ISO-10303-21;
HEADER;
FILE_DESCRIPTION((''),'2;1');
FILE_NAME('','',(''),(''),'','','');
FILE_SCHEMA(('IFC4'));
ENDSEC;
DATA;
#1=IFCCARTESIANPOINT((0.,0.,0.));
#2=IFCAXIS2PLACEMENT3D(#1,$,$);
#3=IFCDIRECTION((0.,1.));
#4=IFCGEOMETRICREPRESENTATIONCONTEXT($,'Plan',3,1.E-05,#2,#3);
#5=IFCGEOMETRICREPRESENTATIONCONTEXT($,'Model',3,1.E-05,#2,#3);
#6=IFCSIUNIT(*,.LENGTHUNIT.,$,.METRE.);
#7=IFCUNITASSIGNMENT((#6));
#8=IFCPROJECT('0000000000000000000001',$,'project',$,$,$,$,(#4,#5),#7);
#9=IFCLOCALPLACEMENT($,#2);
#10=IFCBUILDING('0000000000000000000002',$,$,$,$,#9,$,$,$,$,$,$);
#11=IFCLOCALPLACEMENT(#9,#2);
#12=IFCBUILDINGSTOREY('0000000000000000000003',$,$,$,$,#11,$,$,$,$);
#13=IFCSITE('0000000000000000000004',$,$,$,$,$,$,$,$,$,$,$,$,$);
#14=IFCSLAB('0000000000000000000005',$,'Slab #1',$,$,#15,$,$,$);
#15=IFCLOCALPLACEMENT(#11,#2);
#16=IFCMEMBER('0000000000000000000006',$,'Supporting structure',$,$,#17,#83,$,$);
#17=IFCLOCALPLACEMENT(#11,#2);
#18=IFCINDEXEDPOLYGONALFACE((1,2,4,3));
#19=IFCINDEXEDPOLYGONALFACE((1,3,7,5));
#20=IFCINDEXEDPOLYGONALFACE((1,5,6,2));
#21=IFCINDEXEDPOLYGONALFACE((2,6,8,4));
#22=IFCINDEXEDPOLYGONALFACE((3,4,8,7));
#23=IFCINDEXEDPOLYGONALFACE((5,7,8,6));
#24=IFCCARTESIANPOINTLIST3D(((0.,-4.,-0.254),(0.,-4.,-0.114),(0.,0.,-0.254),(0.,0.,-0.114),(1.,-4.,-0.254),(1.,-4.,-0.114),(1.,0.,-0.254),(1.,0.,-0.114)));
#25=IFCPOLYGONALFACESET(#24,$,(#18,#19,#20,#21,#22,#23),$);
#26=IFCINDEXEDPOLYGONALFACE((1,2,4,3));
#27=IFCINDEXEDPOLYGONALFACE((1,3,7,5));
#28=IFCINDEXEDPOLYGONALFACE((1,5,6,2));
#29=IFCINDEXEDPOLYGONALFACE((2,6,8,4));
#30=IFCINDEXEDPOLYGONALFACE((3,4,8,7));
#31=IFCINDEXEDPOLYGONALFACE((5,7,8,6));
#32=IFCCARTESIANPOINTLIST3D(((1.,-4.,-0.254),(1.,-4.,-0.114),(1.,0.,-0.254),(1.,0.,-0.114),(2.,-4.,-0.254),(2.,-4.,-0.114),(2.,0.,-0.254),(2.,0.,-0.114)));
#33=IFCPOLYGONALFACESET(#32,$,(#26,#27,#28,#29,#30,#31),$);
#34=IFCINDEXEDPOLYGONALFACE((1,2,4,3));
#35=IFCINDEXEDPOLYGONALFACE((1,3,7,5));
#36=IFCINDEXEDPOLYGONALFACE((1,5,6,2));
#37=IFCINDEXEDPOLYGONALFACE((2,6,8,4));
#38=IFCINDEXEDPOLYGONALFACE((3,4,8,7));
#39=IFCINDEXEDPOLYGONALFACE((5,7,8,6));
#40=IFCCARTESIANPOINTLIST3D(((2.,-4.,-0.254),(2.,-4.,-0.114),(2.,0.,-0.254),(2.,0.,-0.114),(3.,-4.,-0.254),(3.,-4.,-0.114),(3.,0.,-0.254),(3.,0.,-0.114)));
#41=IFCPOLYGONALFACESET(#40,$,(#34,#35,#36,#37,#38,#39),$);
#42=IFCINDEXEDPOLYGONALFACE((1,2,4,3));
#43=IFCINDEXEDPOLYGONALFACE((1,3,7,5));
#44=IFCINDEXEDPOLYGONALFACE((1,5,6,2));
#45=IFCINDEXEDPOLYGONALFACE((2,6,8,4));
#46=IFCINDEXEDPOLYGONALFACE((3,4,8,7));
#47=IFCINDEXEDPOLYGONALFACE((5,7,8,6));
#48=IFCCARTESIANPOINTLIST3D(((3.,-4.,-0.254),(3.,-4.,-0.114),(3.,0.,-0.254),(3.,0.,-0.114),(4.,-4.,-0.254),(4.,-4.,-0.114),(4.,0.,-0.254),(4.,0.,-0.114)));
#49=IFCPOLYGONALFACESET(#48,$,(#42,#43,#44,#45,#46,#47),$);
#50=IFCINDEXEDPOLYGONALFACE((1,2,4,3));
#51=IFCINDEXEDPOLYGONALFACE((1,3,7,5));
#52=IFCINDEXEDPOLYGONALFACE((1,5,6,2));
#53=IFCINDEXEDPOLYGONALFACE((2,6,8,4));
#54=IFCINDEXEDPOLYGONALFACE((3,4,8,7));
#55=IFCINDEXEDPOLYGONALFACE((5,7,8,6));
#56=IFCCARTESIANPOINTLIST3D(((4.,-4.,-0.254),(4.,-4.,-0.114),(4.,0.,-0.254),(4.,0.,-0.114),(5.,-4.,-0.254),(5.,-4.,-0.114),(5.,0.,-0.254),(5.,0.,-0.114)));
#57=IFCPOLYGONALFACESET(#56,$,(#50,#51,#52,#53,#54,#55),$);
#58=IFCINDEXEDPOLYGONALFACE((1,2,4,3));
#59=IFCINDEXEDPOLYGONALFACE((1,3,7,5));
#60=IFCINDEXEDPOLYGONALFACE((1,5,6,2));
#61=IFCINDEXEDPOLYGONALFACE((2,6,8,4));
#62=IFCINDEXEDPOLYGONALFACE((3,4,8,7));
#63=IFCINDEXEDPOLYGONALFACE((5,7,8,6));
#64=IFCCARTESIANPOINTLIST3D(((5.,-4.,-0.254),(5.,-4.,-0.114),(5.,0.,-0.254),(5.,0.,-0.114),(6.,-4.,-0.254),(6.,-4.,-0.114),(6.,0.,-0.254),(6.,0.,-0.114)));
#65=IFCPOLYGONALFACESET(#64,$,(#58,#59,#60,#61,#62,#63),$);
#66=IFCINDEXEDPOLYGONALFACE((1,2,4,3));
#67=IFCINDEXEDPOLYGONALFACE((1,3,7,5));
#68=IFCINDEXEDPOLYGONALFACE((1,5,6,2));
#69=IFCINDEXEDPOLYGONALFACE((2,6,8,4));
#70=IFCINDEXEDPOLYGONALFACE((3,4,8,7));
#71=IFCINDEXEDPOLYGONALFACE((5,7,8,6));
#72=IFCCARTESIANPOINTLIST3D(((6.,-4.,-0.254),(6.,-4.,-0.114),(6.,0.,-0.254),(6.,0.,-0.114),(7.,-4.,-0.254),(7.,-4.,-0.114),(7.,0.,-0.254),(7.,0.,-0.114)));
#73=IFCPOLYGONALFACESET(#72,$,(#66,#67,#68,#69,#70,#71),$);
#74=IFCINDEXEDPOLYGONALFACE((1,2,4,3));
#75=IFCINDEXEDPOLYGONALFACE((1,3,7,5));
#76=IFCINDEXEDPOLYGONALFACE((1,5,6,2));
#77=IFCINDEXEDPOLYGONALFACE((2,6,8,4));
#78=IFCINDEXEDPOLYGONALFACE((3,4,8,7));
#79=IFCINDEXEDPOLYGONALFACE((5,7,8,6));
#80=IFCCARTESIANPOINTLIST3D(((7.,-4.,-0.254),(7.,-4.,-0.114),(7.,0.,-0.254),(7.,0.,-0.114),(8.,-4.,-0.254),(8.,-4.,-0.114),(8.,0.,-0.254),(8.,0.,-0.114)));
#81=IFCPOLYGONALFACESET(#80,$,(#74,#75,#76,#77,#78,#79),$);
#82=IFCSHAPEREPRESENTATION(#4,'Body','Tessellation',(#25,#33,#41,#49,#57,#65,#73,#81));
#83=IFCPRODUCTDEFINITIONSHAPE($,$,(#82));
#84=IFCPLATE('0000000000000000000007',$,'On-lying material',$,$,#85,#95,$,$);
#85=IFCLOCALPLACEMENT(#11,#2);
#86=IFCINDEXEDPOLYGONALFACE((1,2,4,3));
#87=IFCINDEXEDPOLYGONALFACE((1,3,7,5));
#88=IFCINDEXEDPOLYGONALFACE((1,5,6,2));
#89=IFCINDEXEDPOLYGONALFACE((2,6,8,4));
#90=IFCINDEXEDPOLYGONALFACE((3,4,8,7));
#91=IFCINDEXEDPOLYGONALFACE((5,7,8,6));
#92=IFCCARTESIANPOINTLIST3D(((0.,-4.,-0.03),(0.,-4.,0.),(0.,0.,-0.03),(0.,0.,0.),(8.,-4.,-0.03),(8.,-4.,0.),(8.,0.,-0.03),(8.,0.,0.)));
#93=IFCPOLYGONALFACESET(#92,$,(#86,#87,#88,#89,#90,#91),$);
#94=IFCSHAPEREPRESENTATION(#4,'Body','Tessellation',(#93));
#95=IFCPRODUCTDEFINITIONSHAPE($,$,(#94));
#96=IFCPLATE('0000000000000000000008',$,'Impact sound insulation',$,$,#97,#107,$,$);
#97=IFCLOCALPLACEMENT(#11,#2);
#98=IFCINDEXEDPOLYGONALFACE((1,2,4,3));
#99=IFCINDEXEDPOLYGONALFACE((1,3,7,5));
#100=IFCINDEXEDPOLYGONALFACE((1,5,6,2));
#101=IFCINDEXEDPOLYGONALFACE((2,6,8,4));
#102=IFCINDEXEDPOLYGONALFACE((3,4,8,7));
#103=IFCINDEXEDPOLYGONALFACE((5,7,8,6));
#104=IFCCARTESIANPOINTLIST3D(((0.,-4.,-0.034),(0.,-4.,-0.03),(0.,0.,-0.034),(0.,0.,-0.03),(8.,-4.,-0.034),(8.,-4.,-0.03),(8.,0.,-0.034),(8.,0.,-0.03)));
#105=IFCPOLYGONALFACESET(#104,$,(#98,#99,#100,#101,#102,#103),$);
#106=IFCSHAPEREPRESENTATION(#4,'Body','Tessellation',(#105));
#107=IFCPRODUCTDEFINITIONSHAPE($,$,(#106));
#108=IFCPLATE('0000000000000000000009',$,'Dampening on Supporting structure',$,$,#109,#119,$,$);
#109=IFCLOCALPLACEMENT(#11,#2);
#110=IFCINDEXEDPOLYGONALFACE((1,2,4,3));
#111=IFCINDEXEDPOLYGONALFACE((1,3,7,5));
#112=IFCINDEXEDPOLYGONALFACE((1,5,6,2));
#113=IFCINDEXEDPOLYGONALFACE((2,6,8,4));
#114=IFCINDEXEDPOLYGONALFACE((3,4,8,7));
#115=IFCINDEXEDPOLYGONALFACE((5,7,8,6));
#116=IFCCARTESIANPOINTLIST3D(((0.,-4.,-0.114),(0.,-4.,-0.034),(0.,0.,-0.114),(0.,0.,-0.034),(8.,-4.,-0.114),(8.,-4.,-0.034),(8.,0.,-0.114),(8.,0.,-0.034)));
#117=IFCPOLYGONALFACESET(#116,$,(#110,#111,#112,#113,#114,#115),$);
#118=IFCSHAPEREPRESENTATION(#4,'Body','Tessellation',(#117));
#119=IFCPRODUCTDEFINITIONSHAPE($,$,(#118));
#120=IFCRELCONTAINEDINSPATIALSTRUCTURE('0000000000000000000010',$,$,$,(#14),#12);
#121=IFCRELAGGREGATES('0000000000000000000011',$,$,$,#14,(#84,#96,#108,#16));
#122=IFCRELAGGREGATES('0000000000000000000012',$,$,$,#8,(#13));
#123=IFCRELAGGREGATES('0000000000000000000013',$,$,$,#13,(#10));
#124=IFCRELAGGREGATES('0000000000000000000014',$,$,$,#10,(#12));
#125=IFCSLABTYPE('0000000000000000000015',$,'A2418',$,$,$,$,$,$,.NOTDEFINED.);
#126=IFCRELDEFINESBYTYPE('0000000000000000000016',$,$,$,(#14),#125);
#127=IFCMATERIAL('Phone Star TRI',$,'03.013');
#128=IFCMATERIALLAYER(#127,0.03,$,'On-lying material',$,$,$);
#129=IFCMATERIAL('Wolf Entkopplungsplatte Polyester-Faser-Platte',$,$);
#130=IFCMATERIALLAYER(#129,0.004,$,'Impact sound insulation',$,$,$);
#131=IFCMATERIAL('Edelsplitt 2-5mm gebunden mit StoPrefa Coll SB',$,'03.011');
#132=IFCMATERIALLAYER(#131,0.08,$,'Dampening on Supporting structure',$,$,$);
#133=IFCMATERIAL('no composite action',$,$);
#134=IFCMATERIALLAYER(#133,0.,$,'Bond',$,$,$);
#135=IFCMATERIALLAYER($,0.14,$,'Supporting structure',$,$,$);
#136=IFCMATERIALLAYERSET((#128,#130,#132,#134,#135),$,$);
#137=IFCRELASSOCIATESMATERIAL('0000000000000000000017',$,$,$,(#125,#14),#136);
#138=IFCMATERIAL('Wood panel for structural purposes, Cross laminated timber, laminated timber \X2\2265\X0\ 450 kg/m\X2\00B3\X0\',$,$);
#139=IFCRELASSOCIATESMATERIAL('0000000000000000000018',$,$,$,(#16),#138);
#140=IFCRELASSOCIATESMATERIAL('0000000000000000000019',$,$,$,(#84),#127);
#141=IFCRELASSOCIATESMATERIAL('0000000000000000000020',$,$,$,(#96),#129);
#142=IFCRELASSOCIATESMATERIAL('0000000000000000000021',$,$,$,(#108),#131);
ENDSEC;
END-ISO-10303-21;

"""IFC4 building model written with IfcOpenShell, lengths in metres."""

from ifc_helpers import new_model, si_unit, direction, frame, frame_2d, origin, origin_with_axes, place, context, project, spatial, rectangle, extrude, material, layer, layer_set, type_object, element, aggregate, save


model = new_model("IFC4")

# Units and contexts
plan_context = context("Plan", 3, precision=1e-05, world=origin(), true_north=direction((0.0, 1.0)))
model_context = context("Model", 3, precision=1e-05, world=origin(), true_north=direction((0.0, 1.0)))
ifc_project = project(units=[si_unit("LENGTHUNIT", "METRE")], contexts=[plan_context, model_context])

# Site, building, storey
site = spatial("IfcSite", under=ifc_project)
building_placement = place(None, origin())
building = spatial("IfcBuilding", under=site, at=building_placement)
storey_placement = place(building_placement, origin())
storey = spatial("IfcBuildingStorey", under=building, at=storey_placement)

# Slab, member, plates
ifc_material_1 = material(Name="Phone Star TRI", Category="03.013")
ifc_layer_1 = layer(ifc_material_1, 0.03, Name="On-lying material")
ifc_material_2 = material(Name="Wolf Entkopplungsplatte Polyester-Faser-Platte")
ifc_layer_2 = layer(ifc_material_2, 0.004, Name="Impact sound insulation")
ifc_material_3 = material(Name="Edelsplitt 2-5mm gebunden mit StoPrefa Coll SB", Category="03.011")
ifc_layer_3 = layer(ifc_material_3, 0.08, Name="Dampening on Supporting structure")
ifc_material_4 = material(Name="no composite action")
ifc_layer_4 = layer(ifc_material_4, 0.0, Name="Bond")
ifc_layer_5 = layer(None, 0.14, Name="Supporting structure")
ifc_layer_set = layer_set([ifc_layer_1, ifc_layer_2, ifc_layer_3, ifc_layer_4, ifc_layer_5])
slab_type = type_object("IfcSlabType", Name="A2418", PredefinedType="NOTDEFINED", material=ifc_layer_set)
slab_placement = place(None, frame((0.0, 0.0, 0.0), z_axis=(0.0, 0.0, -1.0), x_axis=(1.0, 0.0, 0.0)))
slab = element("IfcSlab", 1, at=slab_placement, inside=storey, type_object=slab_type, material=ifc_layer_set, Name="Slab #1")
ifc_material_5 = material(Name="Wood panel for structural purposes, Cross laminated timber, laminated timber ≥ 450 kg/m³")
member_placement = place(slab_placement, origin())
member = element("IfcMember", 2, at=member_placement, material=ifc_material_5, Name="Supporting structure", context=plan_context, shape_type="SweptSolid", body=[
    extrude(rectangle(XDim=1.0, YDim=0.14, at=frame_2d((0.5, 0.07), x_axis=(1.0, 0.0))), frame((0.0, 4.0, 0.114), z_axis=(0.0, -1.0, 0.0), x_axis=(1.0, 0.0, 0.0)), (0.0, 0.0, 1.0), 4.0),
    extrude(rectangle(XDim=1.0, YDim=0.14, at=frame_2d((0.5, 0.07), x_axis=(1.0, 0.0))), frame((1.0, 4.0, 0.114), z_axis=(0.0, -1.0, 0.0), x_axis=(1.0, 0.0, 0.0)), (0.0, 0.0, 1.0), 4.0),
    extrude(rectangle(XDim=1.0, YDim=0.14, at=frame_2d((0.5, 0.07), x_axis=(1.0, 0.0))), frame((2.0, 4.0, 0.114), z_axis=(0.0, -1.0, 0.0), x_axis=(1.0, 0.0, 0.0)), (0.0, 0.0, 1.0), 4.0),
    extrude(rectangle(XDim=1.0, YDim=0.14, at=frame_2d((0.5, 0.07), x_axis=(1.0, 0.0))), frame((3.0, 4.0, 0.114), z_axis=(0.0, -1.0, 0.0), x_axis=(1.0, 0.0, 0.0)), (0.0, 0.0, 1.0), 4.0),
    extrude(rectangle(XDim=1.0, YDim=0.14, at=frame_2d((0.5, 0.07), x_axis=(1.0, 0.0))), frame((4.0, 4.0, 0.114), z_axis=(0.0, -1.0, 0.0), x_axis=(1.0, 0.0, 0.0)), (0.0, 0.0, 1.0), 4.0),
    extrude(rectangle(XDim=1.0, YDim=0.14, at=frame_2d((0.5, 0.07), x_axis=(1.0, 0.0))), frame((5.0, 4.0, 0.114), z_axis=(0.0, -1.0, 0.0), x_axis=(1.0, 0.0, 0.0)), (0.0, 0.0, 1.0), 4.0),
    extrude(rectangle(XDim=1.0, YDim=0.14, at=frame_2d((0.5, 0.07), x_axis=(1.0, 0.0))), frame((6.0, 4.0, 0.114), z_axis=(0.0, -1.0, 0.0), x_axis=(1.0, 0.0, 0.0)), (0.0, 0.0, 1.0), 4.0),
    extrude(rectangle(XDim=1.0, YDim=0.14, at=frame_2d((0.5, 0.07), x_axis=(1.0, 0.0))), frame((7.0, 4.0, 0.114), z_axis=(0.0, -1.0, 0.0), x_axis=(1.0, 0.0, 0.0)), (0.0, 0.0, 1.0), 4.0),
])
plate_1_placement = place(slab_placement, origin())
plate_1 = element("IfcPlate", 3, at=plate_1_placement, material=ifc_material_1, Name="On-lying material", context=plan_context, shape_type="SweptSolid", body=[
    extrude(rectangle(XDim=8.0, YDim=4.0, at=frame_2d((4.0, 2.0), x_axis=(1.0, 0.0))), origin_with_axes(), (0.0, 0.0, 1.0), 0.03),
])
plate_2_placement = place(slab_placement, origin())
plate_2 = element("IfcPlate", 4, at=plate_2_placement, material=ifc_material_2, Name="Impact sound insulation", context=plan_context, shape_type="SweptSolid", body=[
    extrude(rectangle(XDim=8.0, YDim=4.0, at=frame_2d((4.0, 2.0), x_axis=(1.0, 0.0))), frame((0.0, 0.0, 0.03), z_axis=(0.0, 0.0, 1.0), x_axis=(1.0, 0.0, 0.0)), (0.0, 0.0, 1.0), 0.004),
])
plate_3_placement = place(slab_placement, origin())
plate_3 = element("IfcPlate", 5, at=plate_3_placement, material=ifc_material_3, Name="Dampening on Supporting structure", context=plan_context, shape_type="SweptSolid", body=[
    extrude(rectangle(XDim=8.0, YDim=4.0, at=frame_2d((4.0, 2.0), x_axis=(1.0, 0.0))), frame((0.0, 0.0, 0.034), z_axis=(0.0, 0.0, 1.0), x_axis=(1.0, 0.0, 0.0)), (0.0, 0.0, 1.0), 0.08),
])
aggregate(slab, [plate_1, plate_2, plate_3, member])

save(model, "model.ifc")
